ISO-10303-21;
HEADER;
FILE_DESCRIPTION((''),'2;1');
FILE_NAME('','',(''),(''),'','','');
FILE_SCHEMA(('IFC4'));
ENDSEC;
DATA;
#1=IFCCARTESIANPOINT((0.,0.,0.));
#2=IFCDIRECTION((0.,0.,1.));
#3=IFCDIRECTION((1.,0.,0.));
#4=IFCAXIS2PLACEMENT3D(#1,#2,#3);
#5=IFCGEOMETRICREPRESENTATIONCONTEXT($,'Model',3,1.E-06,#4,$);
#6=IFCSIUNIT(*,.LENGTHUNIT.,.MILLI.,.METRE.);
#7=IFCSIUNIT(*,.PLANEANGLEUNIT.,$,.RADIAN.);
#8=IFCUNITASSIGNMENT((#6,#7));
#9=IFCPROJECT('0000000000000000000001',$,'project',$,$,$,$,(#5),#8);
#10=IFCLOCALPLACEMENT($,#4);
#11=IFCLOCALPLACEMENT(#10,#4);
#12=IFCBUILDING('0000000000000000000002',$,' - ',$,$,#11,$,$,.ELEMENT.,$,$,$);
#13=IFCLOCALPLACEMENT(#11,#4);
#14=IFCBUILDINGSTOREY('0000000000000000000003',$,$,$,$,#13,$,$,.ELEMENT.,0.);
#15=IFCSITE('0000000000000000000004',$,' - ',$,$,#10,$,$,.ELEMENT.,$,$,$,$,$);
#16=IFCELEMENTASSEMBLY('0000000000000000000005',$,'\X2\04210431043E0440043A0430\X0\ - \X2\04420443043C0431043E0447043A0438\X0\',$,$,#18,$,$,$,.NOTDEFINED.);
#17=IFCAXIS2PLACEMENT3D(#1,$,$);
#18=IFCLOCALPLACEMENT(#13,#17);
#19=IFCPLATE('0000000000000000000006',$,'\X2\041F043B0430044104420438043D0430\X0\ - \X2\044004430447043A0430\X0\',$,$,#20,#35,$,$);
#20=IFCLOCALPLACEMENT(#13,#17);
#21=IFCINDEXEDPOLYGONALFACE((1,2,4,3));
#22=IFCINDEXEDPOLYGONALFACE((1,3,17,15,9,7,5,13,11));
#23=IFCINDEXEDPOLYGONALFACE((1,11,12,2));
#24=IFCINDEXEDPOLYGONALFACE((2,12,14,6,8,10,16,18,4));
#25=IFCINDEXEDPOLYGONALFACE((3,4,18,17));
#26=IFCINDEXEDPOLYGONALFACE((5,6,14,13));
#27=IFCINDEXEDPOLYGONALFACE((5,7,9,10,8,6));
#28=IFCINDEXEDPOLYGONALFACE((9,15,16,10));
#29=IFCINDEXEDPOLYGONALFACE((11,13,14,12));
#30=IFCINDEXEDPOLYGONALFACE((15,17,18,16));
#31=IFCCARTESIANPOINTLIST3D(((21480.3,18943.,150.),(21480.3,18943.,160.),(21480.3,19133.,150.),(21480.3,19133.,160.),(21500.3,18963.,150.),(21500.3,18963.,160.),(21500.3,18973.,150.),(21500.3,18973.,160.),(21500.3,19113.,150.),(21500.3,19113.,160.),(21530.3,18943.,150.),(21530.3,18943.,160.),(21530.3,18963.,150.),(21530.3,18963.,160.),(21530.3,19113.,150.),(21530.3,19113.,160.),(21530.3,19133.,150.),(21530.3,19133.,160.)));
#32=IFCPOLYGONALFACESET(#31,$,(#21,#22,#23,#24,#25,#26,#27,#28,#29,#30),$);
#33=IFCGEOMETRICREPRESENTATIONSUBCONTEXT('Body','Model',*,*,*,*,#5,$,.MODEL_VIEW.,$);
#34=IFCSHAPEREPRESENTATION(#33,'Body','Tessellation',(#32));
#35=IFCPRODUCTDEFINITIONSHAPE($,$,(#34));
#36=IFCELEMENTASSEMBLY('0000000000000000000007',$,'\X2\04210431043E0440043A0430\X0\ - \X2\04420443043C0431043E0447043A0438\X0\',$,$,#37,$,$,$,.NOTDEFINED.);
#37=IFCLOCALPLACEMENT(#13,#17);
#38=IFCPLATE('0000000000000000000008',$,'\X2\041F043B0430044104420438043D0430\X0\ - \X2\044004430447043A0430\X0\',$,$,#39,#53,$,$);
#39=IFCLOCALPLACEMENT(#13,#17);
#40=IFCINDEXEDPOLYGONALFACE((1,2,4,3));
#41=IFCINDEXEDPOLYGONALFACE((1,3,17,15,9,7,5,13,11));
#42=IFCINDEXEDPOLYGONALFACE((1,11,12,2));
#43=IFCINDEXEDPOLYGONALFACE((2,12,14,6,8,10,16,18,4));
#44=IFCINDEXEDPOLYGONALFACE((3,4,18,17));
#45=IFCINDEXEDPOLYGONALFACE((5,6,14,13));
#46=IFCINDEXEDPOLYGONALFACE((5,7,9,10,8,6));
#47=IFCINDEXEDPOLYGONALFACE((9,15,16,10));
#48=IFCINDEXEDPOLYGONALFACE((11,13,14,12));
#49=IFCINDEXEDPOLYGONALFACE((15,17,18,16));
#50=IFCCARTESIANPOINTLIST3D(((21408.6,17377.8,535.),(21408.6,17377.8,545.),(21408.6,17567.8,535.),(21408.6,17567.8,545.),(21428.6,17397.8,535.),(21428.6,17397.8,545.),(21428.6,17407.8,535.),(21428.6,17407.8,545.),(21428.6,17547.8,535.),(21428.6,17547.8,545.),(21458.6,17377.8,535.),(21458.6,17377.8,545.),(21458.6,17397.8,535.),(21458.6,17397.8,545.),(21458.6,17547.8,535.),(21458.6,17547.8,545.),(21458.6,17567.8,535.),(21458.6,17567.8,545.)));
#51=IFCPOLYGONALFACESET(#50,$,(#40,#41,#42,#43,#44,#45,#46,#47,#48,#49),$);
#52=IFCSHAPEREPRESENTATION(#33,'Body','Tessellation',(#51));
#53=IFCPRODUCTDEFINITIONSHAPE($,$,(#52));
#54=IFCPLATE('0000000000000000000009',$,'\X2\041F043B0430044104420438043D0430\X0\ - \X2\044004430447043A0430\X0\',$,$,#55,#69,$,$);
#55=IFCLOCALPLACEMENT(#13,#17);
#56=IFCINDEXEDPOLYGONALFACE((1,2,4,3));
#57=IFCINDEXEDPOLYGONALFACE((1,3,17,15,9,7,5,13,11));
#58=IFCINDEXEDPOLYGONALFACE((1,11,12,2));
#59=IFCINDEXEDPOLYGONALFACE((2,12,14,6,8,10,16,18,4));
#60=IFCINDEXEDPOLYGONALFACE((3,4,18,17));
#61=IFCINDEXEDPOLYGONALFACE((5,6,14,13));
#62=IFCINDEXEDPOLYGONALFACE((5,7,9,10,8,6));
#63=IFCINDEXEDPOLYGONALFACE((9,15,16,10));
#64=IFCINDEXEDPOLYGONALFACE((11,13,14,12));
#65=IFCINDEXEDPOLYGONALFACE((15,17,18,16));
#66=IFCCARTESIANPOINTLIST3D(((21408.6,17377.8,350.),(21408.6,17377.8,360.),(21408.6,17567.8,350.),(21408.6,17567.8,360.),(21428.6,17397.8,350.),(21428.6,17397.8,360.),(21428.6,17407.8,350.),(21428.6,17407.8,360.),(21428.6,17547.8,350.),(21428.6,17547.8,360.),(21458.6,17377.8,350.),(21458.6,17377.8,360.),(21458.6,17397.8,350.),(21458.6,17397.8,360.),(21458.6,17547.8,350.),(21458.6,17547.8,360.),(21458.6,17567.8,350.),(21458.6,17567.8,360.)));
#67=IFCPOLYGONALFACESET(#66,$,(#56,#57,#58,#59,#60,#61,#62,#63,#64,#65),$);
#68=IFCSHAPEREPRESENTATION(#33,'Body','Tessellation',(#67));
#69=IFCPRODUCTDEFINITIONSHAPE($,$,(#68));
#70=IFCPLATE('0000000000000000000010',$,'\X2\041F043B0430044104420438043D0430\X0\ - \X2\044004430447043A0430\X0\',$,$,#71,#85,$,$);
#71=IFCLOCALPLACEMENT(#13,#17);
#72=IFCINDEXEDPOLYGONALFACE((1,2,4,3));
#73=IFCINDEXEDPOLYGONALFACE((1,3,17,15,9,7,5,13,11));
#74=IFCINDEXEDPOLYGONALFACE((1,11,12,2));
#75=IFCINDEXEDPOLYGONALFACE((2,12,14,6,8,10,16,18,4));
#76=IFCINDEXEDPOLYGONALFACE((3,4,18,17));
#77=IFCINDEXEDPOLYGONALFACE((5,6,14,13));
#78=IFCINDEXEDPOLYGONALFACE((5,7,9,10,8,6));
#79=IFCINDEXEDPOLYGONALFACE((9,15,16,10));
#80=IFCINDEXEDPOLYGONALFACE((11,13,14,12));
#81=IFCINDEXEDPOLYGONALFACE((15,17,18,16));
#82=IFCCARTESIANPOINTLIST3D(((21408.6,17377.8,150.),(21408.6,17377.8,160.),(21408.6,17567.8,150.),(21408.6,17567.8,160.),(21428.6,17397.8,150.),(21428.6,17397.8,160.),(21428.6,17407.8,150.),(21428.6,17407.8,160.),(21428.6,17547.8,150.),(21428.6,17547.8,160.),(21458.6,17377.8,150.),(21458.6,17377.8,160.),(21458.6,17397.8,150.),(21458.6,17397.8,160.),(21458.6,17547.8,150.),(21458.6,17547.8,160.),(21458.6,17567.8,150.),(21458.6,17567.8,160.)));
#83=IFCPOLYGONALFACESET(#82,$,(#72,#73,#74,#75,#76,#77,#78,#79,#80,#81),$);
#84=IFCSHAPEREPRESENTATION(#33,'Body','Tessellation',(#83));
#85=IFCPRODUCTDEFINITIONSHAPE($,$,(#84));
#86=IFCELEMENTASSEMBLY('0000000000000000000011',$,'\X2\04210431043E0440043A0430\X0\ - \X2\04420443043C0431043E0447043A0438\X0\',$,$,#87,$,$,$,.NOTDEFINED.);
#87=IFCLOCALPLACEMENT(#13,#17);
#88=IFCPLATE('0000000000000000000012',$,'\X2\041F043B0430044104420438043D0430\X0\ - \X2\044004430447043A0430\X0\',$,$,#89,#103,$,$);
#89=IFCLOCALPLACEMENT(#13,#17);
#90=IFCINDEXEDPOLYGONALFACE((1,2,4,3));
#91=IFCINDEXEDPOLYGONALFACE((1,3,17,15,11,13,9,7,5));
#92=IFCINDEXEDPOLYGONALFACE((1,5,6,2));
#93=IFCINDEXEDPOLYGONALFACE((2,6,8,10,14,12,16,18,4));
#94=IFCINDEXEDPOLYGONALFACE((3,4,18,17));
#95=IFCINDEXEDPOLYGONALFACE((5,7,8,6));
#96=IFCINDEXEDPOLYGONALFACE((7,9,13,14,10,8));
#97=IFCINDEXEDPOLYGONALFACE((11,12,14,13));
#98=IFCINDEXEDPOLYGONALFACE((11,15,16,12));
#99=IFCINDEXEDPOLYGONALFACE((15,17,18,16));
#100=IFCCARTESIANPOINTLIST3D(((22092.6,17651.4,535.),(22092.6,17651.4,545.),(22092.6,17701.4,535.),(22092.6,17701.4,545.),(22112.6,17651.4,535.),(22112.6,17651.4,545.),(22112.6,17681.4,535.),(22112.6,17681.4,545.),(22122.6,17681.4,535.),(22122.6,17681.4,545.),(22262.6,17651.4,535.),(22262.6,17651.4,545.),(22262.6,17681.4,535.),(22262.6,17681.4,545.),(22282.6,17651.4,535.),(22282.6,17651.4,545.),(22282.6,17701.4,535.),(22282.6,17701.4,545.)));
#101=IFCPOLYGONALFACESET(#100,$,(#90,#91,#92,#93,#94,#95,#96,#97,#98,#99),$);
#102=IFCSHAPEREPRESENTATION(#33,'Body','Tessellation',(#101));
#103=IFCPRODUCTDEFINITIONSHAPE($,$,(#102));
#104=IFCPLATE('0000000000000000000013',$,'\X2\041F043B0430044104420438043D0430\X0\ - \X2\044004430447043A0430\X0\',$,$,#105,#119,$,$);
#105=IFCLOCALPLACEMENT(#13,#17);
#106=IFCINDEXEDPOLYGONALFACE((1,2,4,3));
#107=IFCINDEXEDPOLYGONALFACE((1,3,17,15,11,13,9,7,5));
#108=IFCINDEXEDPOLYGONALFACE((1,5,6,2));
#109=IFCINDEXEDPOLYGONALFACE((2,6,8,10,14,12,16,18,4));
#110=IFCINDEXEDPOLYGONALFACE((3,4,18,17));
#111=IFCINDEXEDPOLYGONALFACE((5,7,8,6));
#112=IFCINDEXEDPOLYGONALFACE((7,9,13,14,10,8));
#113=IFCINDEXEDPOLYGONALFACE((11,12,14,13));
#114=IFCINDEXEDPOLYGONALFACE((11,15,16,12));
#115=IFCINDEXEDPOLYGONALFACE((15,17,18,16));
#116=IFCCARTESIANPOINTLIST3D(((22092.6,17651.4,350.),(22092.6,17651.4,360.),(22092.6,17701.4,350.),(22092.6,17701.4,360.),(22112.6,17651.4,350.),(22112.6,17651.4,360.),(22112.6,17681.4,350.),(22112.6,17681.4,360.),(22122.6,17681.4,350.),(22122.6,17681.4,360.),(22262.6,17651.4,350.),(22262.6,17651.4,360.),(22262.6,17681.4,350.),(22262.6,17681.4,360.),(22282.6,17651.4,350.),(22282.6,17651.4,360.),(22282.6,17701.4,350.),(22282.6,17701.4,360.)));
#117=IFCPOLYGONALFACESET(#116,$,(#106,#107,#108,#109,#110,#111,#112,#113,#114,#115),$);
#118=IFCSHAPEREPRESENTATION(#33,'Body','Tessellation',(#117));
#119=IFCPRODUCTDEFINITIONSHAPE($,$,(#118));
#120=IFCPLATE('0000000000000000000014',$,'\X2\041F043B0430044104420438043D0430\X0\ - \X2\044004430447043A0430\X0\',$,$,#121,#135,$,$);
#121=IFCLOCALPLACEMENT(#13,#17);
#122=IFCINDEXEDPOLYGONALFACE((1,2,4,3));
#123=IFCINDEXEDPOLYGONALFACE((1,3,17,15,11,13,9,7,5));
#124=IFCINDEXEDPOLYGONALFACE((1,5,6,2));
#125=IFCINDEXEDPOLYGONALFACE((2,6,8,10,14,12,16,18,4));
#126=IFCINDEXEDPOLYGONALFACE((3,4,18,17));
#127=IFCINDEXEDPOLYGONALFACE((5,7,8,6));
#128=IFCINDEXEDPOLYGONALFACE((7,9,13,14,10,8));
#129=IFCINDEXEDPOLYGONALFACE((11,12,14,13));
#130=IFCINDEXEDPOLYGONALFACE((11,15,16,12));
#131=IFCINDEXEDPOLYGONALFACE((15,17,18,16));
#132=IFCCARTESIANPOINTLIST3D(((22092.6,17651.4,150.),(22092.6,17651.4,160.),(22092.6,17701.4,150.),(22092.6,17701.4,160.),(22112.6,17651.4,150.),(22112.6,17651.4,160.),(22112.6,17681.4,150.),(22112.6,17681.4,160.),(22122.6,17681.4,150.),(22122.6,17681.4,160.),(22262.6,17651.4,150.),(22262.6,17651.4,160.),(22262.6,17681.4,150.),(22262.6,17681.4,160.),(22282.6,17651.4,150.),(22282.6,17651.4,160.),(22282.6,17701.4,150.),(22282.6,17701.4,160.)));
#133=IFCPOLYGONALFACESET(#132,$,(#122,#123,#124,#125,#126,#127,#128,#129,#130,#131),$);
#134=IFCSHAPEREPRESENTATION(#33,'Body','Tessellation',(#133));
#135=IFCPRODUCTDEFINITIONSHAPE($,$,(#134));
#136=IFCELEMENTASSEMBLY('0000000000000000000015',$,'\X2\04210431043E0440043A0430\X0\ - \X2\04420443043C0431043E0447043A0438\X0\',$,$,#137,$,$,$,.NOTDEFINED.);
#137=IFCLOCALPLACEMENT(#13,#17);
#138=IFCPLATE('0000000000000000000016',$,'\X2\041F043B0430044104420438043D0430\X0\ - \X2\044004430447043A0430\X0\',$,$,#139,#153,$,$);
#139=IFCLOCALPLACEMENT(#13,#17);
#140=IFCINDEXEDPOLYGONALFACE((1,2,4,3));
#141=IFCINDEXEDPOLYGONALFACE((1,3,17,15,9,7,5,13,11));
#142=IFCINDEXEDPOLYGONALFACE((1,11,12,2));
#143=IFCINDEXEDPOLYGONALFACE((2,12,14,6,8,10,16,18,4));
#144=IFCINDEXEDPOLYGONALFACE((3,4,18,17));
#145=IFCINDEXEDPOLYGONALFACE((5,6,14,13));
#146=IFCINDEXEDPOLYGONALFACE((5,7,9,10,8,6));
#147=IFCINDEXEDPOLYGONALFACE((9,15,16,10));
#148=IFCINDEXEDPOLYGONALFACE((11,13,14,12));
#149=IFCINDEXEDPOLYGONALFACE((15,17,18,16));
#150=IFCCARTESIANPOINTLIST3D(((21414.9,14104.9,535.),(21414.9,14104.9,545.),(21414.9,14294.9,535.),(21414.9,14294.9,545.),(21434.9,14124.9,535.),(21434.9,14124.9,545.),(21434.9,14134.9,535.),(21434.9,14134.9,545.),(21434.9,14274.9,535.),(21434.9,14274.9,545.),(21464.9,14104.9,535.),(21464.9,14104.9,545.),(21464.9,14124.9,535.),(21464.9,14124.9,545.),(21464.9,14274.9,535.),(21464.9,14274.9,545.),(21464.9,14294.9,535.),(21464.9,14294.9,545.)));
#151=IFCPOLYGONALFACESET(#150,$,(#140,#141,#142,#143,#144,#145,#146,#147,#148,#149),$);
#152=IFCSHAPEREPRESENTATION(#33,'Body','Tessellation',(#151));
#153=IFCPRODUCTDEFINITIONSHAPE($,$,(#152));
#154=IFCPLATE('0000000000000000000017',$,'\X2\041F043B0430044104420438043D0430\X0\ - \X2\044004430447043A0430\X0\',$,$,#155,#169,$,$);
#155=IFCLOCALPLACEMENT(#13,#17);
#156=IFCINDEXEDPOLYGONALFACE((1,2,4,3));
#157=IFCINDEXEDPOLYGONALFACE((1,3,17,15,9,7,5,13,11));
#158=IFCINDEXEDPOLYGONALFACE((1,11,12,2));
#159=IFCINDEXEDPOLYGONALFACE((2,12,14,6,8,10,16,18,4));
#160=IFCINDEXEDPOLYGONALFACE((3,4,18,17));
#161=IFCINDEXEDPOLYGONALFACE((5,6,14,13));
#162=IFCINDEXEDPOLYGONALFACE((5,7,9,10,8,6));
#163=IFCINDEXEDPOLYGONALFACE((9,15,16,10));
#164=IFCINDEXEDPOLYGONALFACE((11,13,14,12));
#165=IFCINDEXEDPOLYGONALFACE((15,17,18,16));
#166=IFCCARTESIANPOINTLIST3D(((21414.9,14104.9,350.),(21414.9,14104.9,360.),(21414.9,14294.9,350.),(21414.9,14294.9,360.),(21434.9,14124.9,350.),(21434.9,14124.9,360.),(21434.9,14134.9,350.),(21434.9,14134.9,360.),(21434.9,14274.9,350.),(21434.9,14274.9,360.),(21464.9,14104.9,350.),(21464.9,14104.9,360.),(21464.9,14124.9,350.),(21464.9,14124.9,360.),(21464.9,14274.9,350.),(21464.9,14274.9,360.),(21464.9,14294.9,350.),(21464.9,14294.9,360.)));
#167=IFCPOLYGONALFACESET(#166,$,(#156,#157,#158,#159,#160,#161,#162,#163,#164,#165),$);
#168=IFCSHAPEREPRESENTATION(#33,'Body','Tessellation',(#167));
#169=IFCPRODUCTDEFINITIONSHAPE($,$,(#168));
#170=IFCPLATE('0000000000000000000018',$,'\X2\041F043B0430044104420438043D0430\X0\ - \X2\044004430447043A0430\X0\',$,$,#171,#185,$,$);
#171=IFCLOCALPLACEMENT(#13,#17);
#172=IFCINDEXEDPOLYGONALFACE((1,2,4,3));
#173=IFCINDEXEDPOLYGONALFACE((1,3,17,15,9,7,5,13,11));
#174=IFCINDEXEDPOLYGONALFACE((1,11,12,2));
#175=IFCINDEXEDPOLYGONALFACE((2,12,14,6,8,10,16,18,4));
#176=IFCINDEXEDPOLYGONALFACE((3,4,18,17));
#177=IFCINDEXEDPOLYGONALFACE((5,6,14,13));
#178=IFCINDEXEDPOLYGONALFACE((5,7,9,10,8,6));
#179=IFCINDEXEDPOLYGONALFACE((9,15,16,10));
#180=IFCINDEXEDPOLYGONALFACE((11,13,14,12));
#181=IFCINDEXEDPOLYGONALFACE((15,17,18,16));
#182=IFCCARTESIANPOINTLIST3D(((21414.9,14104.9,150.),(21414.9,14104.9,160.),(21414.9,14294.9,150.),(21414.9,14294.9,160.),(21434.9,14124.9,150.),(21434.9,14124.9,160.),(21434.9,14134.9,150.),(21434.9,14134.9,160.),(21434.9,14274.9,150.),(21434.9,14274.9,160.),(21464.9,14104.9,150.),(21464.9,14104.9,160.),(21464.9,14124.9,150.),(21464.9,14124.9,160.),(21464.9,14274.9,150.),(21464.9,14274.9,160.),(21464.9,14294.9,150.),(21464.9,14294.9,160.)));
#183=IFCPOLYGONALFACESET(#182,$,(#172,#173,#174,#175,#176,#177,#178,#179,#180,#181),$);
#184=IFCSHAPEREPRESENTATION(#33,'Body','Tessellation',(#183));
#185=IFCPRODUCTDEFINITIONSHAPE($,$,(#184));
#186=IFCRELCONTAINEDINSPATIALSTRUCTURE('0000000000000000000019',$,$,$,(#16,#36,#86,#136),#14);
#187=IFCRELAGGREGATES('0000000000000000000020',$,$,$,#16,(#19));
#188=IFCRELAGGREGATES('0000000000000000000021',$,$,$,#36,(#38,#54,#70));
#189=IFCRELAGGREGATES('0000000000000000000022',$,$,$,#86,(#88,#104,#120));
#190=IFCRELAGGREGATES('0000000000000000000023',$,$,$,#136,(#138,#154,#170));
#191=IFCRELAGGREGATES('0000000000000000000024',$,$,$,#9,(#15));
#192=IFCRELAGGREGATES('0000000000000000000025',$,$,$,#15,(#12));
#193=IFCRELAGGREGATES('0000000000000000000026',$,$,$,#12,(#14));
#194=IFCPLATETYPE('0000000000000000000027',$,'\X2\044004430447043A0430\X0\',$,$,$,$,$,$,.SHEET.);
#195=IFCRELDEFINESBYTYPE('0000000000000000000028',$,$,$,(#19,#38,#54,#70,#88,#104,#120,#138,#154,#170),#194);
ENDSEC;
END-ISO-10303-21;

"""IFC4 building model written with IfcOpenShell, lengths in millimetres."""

from ifc_helpers import new_model, si_unit, frame, origin_with_axes, place, context, subcontext, project, spatial, line, indexed_curve, outline, extrude, source, transform, mapped, type_object, element, aggregate, save


model = new_model("IFC4")

# Units and contexts
model_context = context("Model", 3, precision=1e-06, world=origin_with_axes())
body_context = subcontext(model_context, "Body", "Model", "MODEL_VIEW")
ifc_project = project(units=[si_unit("LENGTHUNIT", "METRE", prefix="MILLI"), si_unit("PLANEANGLEUNIT", "RADIAN")], contexts=[model_context])

# Site, building, storey
site_placement = place(None, origin_with_axes())
site = spatial("IfcSite", under=ifc_project, at=site_placement, Name=" - ", CompositionType="ELEMENT")
building_placement = place(site_placement, origin_with_axes())
building = spatial("IfcBuilding", under=site, at=building_placement, Name=" - ", CompositionType="ELEMENT")
storey_placement = place(building_placement, origin_with_axes())
storey = spatial("IfcBuildingStorey", under=building, at=storey_placement, CompositionType="ELEMENT", Elevation=0.0)

# Shared definitions
plate_type = type_object("IfcPlateType", Name="ручка", PredefinedType="SHEET")
shared_shape = source(origin_with_axes(), body_context, "Body", "SweptSolid", [
    extrude(outline(indexed_curve([(-95.0, -25.0), (-75.0, -25.0), (-75.0, 5.0), (-65.0, 5.0), (75.0, 5.0), (75.0, -25.0), (95.0, -25.0), (95.0, 25.0), (-95.0, 25.0)], segments=[line(1, 2), line(2, 3), line(3, 4), line(4, 5), line(5, 6), line(6, 7), line(7, 8), line(8, 9), line(9, 1)])), origin_with_axes(), (0.0, 0.0, 1.0), 10.0),
])

# Element assemblies, plates
assembly_1_placement = place(storey_placement, frame((21530.3, 19238.0, 0.0), z_axis=(0.0, 0.0, 1.0), x_axis=(0.0, -1.0, 0.0)))
assembly_1 = element("IfcElementAssembly", 1, at=assembly_1_placement, inside=storey, Name="Сборка - тумбочки", PredefinedType="NOTDEFINED")
plate_1_placement = place(assembly_1_placement, frame((200.0, -25.0, 150.0), z_axis=(0.0, 0.0, 1.0), x_axis=(-1.0, 0.0, 0.0)))
plate_1 = element("IfcPlate", 2, at=plate_1_placement, type_object=plate_type, Name="Пластина - ручка", context=body_context, shape_type="MappedRepresentation", body=[
    mapped(shared_shape, transform((0.0, 0.0, 0.0), x_axis=(1.0, 0.0, 0.0), y_axis=(0.0, 1.0, 0.0), z_axis=(0.0, 0.0, 1.0), scale=1.0)),
])
aggregate(assembly_1, [plate_1])
assembly_2_placement = place(storey_placement, frame((21458.6, 17672.8, 0.0), z_axis=(0.0, 0.0, 1.0), x_axis=(0.0, -1.0, 0.0)))
assembly_2 = element("IfcElementAssembly", 3, at=assembly_2_placement, inside=storey, Name="Сборка - тумбочки", PredefinedType="NOTDEFINED")
plate_2_placement = place(assembly_2_placement, frame((200.0, -25.0, 535.0), z_axis=(0.0, 0.0, 1.0), x_axis=(-1.0, 0.0, 0.0)))
plate_2 = element("IfcPlate", 4, at=plate_2_placement, type_object=plate_type, Name="Пластина - ручка", context=body_context, shape_type="MappedRepresentation", body=[
    mapped(shared_shape, transform((0.0, 0.0, 0.0), x_axis=(1.0, 0.0, 0.0), y_axis=(0.0, 1.0, 0.0), z_axis=(0.0, 0.0, 1.0), scale=1.0)),
])
plate_3_placement = place(assembly_2_placement, frame((200.0, -25.0, 350.0), z_axis=(0.0, 0.0, 1.0), x_axis=(-1.0, 0.0, 0.0)))
plate_3 = element("IfcPlate", 5, at=plate_3_placement, type_object=plate_type, Name="Пластина - ручка", context=body_context, shape_type="MappedRepresentation", body=[
    mapped(shared_shape, transform((0.0, 0.0, 0.0), x_axis=(1.0, 0.0, 0.0), y_axis=(0.0, 1.0, 0.0), z_axis=(0.0, 0.0, 1.0), scale=1.0)),
])
plate_4_placement = place(assembly_2_placement, frame((200.0, -25.0, 150.0), z_axis=(0.0, 0.0, 1.0), x_axis=(-1.0, 0.0, 0.0)))
plate_4 = element("IfcPlate", 6, at=plate_4_placement, type_object=plate_type, Name="Пластина - ручка", context=body_context, shape_type="MappedRepresentation", body=[
    mapped(shared_shape, transform((0.0, 0.0, 0.0), x_axis=(1.0, 0.0, 0.0), y_axis=(0.0, 1.0, 0.0), z_axis=(0.0, 0.0, 1.0), scale=1.0)),
])
aggregate(assembly_2, [plate_2, plate_3, plate_4])
assembly_3_placement = place(storey_placement, frame((22387.6, 17651.4, 0.0), z_axis=(0.0, 0.0, 1.0), x_axis=(-1.0, 0.0, 0.0)))
assembly_3 = element("IfcElementAssembly", 7, at=assembly_3_placement, inside=storey, Name="Сборка - тумбочки", PredefinedType="NOTDEFINED")
plate_5_placement = place(assembly_3_placement, frame((200.0, -25.0, 535.0), z_axis=(0.0, 0.0, 1.0), x_axis=(-1.0, 0.0, 0.0)))
plate_5 = element("IfcPlate", 8, at=plate_5_placement, type_object=plate_type, Name="Пластина - ручка", context=body_context, shape_type="MappedRepresentation", body=[
    mapped(shared_shape, transform((0.0, 0.0, 0.0), x_axis=(1.0, 0.0, 0.0), y_axis=(0.0, 1.0, 0.0), z_axis=(0.0, 0.0, 1.0), scale=1.0)),
])
plate_6_placement = place(assembly_3_placement, frame((200.0, -25.0, 350.0), z_axis=(0.0, 0.0, 1.0), x_axis=(-1.0, 0.0, 0.0)))
plate_6 = element("IfcPlate", 9, at=plate_6_placement, type_object=plate_type, Name="Пластина - ручка", context=body_context, shape_type="MappedRepresentation", body=[
    mapped(shared_shape, transform((0.0, 0.0, 0.0), x_axis=(1.0, 0.0, 0.0), y_axis=(0.0, 1.0, 0.0), z_axis=(0.0, 0.0, 1.0), scale=1.0)),
])
plate_7_placement = place(assembly_3_placement, frame((200.0, -25.0, 150.0), z_axis=(0.0, 0.0, 1.0), x_axis=(-1.0, 0.0, 0.0)))
plate_7 = element("IfcPlate", 10, at=plate_7_placement, type_object=plate_type, Name="Пластина - ручка", context=body_context, shape_type="MappedRepresentation", body=[
    mapped(shared_shape, transform((0.0, 0.0, 0.0), x_axis=(1.0, 0.0, 0.0), y_axis=(0.0, 1.0, 0.0), z_axis=(0.0, 0.0, 1.0), scale=1.0)),
])
aggregate(assembly_3, [plate_5, plate_6, plate_7])
assembly_4_placement = place(storey_placement, frame((21464.9, 14399.9, 0.0), z_axis=(0.0, 0.0, 1.0), x_axis=(0.0, -1.0, 0.0)))
assembly_4 = element("IfcElementAssembly", 11, at=assembly_4_placement, inside=storey, Name="Сборка - тумбочки", PredefinedType="NOTDEFINED")
plate_8_placement = place(assembly_4_placement, frame((200.0, -25.0, 535.0), z_axis=(0.0, 0.0, 1.0), x_axis=(-1.0, 0.0, 0.0)))
plate_8 = element("IfcPlate", 12, at=plate_8_placement, type_object=plate_type, Name="Пластина - ручка", context=body_context, shape_type="MappedRepresentation", body=[
    mapped(shared_shape, transform((0.0, 0.0, 0.0), x_axis=(1.0, 0.0, 0.0), y_axis=(0.0, 1.0, 0.0), z_axis=(0.0, 0.0, 1.0), scale=1.0)),
])
plate_9_placement = place(assembly_4_placement, frame((200.0, -25.0, 350.0), z_axis=(0.0, 0.0, 1.0), x_axis=(-1.0, 0.0, 0.0)))
plate_9 = element("IfcPlate", 13, at=plate_9_placement, type_object=plate_type, Name="Пластина - ручка", context=body_context, shape_type="MappedRepresentation", body=[
    mapped(shared_shape, transform((0.0, 0.0, 0.0), x_axis=(1.0, 0.0, 0.0), y_axis=(0.0, 1.0, 0.0), z_axis=(0.0, 0.0, 1.0), scale=1.0)),
])
plate_10_placement = place(assembly_4_placement, frame((200.0, -25.0, 150.0), z_axis=(0.0, 0.0, 1.0), x_axis=(-1.0, 0.0, 0.0)))
plate_10 = element("IfcPlate", 14, at=plate_10_placement, type_object=plate_type, Name="Пластина - ручка", context=body_context, shape_type="MappedRepresentation", body=[
    mapped(shared_shape, transform((0.0, 0.0, 0.0), x_axis=(1.0, 0.0, 0.0), y_axis=(0.0, 1.0, 0.0), z_axis=(0.0, 0.0, 1.0), scale=1.0)),
])
aggregate(assembly_4, [plate_8, plate_9, plate_10])

save(model, "model.ifc")
